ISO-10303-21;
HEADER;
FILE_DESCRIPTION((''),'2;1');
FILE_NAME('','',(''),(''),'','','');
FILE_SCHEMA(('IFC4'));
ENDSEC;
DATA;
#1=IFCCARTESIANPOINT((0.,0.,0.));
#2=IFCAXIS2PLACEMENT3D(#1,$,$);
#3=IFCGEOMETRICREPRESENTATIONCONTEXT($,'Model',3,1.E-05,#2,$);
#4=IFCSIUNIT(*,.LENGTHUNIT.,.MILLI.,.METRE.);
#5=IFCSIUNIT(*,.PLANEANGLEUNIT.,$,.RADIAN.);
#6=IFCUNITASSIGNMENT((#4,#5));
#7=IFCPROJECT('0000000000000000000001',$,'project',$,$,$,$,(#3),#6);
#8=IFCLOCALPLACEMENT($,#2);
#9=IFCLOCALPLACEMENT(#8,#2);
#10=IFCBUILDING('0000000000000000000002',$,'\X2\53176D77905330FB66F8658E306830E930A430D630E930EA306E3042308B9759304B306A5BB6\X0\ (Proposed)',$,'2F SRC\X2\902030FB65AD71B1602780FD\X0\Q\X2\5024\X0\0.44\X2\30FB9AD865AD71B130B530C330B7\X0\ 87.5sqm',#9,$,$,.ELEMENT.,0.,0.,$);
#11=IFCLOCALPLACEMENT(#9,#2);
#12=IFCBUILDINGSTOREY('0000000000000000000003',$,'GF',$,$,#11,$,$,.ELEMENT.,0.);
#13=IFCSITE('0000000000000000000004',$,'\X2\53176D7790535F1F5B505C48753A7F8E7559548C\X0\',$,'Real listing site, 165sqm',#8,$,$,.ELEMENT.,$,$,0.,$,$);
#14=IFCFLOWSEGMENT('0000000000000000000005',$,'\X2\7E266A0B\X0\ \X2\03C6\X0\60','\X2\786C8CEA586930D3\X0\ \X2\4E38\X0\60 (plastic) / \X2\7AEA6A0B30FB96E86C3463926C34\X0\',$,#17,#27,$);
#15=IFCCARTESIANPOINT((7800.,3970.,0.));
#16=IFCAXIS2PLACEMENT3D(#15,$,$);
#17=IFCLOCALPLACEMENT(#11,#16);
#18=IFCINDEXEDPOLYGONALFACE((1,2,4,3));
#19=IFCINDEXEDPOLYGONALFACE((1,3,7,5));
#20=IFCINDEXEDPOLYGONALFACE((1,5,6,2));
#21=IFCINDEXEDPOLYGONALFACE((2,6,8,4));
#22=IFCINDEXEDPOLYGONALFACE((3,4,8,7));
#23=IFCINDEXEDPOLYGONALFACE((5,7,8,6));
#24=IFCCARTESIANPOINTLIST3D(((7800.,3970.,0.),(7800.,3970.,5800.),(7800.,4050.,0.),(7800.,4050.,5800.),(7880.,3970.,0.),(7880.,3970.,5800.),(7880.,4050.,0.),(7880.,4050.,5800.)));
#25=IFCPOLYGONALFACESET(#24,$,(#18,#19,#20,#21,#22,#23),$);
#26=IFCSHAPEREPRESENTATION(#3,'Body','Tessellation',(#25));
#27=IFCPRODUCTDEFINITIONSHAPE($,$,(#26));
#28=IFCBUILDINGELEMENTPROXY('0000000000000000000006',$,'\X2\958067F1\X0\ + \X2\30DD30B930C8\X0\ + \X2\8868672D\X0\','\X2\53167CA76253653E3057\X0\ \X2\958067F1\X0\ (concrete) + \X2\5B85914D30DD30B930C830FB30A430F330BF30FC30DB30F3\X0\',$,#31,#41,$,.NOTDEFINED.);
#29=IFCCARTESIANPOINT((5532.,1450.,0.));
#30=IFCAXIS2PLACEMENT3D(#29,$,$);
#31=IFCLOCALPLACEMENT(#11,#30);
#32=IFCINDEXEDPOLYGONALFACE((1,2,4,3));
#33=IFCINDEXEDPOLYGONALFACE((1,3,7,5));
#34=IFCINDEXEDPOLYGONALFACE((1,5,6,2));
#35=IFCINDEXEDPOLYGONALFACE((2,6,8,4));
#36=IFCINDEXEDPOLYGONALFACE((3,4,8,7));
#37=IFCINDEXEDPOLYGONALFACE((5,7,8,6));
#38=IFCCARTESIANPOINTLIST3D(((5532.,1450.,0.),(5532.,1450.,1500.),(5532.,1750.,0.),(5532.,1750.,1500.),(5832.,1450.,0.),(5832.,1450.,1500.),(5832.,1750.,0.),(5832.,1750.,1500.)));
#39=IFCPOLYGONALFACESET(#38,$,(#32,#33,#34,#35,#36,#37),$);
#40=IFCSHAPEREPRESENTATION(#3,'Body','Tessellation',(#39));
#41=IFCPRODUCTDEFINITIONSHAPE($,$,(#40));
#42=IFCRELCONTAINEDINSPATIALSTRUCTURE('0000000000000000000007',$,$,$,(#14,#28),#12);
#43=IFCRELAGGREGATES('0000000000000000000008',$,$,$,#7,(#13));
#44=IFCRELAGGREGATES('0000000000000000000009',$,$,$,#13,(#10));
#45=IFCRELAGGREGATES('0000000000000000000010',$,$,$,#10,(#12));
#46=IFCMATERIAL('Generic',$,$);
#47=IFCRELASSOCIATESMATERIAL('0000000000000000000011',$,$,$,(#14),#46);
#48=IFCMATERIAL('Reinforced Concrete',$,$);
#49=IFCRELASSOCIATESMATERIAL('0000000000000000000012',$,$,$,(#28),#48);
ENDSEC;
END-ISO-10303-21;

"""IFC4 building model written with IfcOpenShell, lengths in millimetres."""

from ifc_helpers import new_model, si_unit, frame, frame_2d, origin, place, context, project, spatial, rectangle, extrude, material, element, save


model = new_model("IFC4")

# Units and contexts
model_context = context("Model", 3, precision=1e-05, world=origin())
ifc_project = project(units=[si_unit("LENGTHUNIT", "METRE", prefix="MILLI"), si_unit("PLANEANGLEUNIT", "RADIAN")], contexts=[model_context])

# Site, building, storey
site_placement = place(None, origin())
site = spatial("IfcSite", under=ifc_project, at=site_placement, Name="北海道弟子屈町美留和", ObjectType="Real listing site, 165sqm", CompositionType="ELEMENT", RefElevation=0.0)
building_placement = place(site_placement, origin())
building = spatial("IfcBuilding", under=site, at=building_placement, Name="北海道・書斎とライブラリのある静かな家 (Proposed)", ObjectType="2F SRC造・断熱性能Q値0.44・高断熱サッシ 87.5sqm", CompositionType="ELEMENT", ElevationOfRefHeight=0.0, ElevationOfTerrain=0.0)
storey_placement = place(building_placement, origin())
storey = spatial("IfcBuildingStorey", under=building, at=storey_placement, Name="GF", CompositionType="ELEMENT", Elevation=0.0)

# Shared definitions
ifc_material_1 = material(Name="Reinforced Concrete")

# Flow segment
ifc_material_2 = material(Name="Generic")
flow_segment_1_placement = place(storey_placement, frame((7800.0, 3970.0, 0.0)))
element("IfcFlowSegment", 1, at=flow_segment_1_placement, inside=storey, material=ifc_material_2, Name="縦樋 φ60", Description="硬質塩ビ 丸60 (plastic) / 竪樋・雨水排水", context=model_context, shape_type="SweptSolid", body=[
    extrude(rectangle(XDim=80.0, YDim=80.0, at=frame_2d((40.0, 40.0))), frame((7800.0, 3970.0, 0.0)), (0.0, 0.0, 1.0), 5800.0),
])

# Building element proxy
proxy_placement = place(storey_placement, frame((5532.0, 1450.0, 0.0)))
element("IfcBuildingElementProxy", 2, at=proxy_placement, inside=storey, material=ifc_material_1, Name="門柱 + ポスト + 表札", Description="化粧打放し 門柱 (concrete) + 宅配ポスト・インターホン", PredefinedType="NOTDEFINED", context=model_context, shape_type="SweptSolid", body=[
    extrude(rectangle(XDim=300.0, YDim=300.0, at=frame_2d((150.0, 150.0))), frame((5532.0, 1450.0, 0.0)), (0.0, 0.0, 1.0), 1500.0),
])

save(model, "model.ifc")
